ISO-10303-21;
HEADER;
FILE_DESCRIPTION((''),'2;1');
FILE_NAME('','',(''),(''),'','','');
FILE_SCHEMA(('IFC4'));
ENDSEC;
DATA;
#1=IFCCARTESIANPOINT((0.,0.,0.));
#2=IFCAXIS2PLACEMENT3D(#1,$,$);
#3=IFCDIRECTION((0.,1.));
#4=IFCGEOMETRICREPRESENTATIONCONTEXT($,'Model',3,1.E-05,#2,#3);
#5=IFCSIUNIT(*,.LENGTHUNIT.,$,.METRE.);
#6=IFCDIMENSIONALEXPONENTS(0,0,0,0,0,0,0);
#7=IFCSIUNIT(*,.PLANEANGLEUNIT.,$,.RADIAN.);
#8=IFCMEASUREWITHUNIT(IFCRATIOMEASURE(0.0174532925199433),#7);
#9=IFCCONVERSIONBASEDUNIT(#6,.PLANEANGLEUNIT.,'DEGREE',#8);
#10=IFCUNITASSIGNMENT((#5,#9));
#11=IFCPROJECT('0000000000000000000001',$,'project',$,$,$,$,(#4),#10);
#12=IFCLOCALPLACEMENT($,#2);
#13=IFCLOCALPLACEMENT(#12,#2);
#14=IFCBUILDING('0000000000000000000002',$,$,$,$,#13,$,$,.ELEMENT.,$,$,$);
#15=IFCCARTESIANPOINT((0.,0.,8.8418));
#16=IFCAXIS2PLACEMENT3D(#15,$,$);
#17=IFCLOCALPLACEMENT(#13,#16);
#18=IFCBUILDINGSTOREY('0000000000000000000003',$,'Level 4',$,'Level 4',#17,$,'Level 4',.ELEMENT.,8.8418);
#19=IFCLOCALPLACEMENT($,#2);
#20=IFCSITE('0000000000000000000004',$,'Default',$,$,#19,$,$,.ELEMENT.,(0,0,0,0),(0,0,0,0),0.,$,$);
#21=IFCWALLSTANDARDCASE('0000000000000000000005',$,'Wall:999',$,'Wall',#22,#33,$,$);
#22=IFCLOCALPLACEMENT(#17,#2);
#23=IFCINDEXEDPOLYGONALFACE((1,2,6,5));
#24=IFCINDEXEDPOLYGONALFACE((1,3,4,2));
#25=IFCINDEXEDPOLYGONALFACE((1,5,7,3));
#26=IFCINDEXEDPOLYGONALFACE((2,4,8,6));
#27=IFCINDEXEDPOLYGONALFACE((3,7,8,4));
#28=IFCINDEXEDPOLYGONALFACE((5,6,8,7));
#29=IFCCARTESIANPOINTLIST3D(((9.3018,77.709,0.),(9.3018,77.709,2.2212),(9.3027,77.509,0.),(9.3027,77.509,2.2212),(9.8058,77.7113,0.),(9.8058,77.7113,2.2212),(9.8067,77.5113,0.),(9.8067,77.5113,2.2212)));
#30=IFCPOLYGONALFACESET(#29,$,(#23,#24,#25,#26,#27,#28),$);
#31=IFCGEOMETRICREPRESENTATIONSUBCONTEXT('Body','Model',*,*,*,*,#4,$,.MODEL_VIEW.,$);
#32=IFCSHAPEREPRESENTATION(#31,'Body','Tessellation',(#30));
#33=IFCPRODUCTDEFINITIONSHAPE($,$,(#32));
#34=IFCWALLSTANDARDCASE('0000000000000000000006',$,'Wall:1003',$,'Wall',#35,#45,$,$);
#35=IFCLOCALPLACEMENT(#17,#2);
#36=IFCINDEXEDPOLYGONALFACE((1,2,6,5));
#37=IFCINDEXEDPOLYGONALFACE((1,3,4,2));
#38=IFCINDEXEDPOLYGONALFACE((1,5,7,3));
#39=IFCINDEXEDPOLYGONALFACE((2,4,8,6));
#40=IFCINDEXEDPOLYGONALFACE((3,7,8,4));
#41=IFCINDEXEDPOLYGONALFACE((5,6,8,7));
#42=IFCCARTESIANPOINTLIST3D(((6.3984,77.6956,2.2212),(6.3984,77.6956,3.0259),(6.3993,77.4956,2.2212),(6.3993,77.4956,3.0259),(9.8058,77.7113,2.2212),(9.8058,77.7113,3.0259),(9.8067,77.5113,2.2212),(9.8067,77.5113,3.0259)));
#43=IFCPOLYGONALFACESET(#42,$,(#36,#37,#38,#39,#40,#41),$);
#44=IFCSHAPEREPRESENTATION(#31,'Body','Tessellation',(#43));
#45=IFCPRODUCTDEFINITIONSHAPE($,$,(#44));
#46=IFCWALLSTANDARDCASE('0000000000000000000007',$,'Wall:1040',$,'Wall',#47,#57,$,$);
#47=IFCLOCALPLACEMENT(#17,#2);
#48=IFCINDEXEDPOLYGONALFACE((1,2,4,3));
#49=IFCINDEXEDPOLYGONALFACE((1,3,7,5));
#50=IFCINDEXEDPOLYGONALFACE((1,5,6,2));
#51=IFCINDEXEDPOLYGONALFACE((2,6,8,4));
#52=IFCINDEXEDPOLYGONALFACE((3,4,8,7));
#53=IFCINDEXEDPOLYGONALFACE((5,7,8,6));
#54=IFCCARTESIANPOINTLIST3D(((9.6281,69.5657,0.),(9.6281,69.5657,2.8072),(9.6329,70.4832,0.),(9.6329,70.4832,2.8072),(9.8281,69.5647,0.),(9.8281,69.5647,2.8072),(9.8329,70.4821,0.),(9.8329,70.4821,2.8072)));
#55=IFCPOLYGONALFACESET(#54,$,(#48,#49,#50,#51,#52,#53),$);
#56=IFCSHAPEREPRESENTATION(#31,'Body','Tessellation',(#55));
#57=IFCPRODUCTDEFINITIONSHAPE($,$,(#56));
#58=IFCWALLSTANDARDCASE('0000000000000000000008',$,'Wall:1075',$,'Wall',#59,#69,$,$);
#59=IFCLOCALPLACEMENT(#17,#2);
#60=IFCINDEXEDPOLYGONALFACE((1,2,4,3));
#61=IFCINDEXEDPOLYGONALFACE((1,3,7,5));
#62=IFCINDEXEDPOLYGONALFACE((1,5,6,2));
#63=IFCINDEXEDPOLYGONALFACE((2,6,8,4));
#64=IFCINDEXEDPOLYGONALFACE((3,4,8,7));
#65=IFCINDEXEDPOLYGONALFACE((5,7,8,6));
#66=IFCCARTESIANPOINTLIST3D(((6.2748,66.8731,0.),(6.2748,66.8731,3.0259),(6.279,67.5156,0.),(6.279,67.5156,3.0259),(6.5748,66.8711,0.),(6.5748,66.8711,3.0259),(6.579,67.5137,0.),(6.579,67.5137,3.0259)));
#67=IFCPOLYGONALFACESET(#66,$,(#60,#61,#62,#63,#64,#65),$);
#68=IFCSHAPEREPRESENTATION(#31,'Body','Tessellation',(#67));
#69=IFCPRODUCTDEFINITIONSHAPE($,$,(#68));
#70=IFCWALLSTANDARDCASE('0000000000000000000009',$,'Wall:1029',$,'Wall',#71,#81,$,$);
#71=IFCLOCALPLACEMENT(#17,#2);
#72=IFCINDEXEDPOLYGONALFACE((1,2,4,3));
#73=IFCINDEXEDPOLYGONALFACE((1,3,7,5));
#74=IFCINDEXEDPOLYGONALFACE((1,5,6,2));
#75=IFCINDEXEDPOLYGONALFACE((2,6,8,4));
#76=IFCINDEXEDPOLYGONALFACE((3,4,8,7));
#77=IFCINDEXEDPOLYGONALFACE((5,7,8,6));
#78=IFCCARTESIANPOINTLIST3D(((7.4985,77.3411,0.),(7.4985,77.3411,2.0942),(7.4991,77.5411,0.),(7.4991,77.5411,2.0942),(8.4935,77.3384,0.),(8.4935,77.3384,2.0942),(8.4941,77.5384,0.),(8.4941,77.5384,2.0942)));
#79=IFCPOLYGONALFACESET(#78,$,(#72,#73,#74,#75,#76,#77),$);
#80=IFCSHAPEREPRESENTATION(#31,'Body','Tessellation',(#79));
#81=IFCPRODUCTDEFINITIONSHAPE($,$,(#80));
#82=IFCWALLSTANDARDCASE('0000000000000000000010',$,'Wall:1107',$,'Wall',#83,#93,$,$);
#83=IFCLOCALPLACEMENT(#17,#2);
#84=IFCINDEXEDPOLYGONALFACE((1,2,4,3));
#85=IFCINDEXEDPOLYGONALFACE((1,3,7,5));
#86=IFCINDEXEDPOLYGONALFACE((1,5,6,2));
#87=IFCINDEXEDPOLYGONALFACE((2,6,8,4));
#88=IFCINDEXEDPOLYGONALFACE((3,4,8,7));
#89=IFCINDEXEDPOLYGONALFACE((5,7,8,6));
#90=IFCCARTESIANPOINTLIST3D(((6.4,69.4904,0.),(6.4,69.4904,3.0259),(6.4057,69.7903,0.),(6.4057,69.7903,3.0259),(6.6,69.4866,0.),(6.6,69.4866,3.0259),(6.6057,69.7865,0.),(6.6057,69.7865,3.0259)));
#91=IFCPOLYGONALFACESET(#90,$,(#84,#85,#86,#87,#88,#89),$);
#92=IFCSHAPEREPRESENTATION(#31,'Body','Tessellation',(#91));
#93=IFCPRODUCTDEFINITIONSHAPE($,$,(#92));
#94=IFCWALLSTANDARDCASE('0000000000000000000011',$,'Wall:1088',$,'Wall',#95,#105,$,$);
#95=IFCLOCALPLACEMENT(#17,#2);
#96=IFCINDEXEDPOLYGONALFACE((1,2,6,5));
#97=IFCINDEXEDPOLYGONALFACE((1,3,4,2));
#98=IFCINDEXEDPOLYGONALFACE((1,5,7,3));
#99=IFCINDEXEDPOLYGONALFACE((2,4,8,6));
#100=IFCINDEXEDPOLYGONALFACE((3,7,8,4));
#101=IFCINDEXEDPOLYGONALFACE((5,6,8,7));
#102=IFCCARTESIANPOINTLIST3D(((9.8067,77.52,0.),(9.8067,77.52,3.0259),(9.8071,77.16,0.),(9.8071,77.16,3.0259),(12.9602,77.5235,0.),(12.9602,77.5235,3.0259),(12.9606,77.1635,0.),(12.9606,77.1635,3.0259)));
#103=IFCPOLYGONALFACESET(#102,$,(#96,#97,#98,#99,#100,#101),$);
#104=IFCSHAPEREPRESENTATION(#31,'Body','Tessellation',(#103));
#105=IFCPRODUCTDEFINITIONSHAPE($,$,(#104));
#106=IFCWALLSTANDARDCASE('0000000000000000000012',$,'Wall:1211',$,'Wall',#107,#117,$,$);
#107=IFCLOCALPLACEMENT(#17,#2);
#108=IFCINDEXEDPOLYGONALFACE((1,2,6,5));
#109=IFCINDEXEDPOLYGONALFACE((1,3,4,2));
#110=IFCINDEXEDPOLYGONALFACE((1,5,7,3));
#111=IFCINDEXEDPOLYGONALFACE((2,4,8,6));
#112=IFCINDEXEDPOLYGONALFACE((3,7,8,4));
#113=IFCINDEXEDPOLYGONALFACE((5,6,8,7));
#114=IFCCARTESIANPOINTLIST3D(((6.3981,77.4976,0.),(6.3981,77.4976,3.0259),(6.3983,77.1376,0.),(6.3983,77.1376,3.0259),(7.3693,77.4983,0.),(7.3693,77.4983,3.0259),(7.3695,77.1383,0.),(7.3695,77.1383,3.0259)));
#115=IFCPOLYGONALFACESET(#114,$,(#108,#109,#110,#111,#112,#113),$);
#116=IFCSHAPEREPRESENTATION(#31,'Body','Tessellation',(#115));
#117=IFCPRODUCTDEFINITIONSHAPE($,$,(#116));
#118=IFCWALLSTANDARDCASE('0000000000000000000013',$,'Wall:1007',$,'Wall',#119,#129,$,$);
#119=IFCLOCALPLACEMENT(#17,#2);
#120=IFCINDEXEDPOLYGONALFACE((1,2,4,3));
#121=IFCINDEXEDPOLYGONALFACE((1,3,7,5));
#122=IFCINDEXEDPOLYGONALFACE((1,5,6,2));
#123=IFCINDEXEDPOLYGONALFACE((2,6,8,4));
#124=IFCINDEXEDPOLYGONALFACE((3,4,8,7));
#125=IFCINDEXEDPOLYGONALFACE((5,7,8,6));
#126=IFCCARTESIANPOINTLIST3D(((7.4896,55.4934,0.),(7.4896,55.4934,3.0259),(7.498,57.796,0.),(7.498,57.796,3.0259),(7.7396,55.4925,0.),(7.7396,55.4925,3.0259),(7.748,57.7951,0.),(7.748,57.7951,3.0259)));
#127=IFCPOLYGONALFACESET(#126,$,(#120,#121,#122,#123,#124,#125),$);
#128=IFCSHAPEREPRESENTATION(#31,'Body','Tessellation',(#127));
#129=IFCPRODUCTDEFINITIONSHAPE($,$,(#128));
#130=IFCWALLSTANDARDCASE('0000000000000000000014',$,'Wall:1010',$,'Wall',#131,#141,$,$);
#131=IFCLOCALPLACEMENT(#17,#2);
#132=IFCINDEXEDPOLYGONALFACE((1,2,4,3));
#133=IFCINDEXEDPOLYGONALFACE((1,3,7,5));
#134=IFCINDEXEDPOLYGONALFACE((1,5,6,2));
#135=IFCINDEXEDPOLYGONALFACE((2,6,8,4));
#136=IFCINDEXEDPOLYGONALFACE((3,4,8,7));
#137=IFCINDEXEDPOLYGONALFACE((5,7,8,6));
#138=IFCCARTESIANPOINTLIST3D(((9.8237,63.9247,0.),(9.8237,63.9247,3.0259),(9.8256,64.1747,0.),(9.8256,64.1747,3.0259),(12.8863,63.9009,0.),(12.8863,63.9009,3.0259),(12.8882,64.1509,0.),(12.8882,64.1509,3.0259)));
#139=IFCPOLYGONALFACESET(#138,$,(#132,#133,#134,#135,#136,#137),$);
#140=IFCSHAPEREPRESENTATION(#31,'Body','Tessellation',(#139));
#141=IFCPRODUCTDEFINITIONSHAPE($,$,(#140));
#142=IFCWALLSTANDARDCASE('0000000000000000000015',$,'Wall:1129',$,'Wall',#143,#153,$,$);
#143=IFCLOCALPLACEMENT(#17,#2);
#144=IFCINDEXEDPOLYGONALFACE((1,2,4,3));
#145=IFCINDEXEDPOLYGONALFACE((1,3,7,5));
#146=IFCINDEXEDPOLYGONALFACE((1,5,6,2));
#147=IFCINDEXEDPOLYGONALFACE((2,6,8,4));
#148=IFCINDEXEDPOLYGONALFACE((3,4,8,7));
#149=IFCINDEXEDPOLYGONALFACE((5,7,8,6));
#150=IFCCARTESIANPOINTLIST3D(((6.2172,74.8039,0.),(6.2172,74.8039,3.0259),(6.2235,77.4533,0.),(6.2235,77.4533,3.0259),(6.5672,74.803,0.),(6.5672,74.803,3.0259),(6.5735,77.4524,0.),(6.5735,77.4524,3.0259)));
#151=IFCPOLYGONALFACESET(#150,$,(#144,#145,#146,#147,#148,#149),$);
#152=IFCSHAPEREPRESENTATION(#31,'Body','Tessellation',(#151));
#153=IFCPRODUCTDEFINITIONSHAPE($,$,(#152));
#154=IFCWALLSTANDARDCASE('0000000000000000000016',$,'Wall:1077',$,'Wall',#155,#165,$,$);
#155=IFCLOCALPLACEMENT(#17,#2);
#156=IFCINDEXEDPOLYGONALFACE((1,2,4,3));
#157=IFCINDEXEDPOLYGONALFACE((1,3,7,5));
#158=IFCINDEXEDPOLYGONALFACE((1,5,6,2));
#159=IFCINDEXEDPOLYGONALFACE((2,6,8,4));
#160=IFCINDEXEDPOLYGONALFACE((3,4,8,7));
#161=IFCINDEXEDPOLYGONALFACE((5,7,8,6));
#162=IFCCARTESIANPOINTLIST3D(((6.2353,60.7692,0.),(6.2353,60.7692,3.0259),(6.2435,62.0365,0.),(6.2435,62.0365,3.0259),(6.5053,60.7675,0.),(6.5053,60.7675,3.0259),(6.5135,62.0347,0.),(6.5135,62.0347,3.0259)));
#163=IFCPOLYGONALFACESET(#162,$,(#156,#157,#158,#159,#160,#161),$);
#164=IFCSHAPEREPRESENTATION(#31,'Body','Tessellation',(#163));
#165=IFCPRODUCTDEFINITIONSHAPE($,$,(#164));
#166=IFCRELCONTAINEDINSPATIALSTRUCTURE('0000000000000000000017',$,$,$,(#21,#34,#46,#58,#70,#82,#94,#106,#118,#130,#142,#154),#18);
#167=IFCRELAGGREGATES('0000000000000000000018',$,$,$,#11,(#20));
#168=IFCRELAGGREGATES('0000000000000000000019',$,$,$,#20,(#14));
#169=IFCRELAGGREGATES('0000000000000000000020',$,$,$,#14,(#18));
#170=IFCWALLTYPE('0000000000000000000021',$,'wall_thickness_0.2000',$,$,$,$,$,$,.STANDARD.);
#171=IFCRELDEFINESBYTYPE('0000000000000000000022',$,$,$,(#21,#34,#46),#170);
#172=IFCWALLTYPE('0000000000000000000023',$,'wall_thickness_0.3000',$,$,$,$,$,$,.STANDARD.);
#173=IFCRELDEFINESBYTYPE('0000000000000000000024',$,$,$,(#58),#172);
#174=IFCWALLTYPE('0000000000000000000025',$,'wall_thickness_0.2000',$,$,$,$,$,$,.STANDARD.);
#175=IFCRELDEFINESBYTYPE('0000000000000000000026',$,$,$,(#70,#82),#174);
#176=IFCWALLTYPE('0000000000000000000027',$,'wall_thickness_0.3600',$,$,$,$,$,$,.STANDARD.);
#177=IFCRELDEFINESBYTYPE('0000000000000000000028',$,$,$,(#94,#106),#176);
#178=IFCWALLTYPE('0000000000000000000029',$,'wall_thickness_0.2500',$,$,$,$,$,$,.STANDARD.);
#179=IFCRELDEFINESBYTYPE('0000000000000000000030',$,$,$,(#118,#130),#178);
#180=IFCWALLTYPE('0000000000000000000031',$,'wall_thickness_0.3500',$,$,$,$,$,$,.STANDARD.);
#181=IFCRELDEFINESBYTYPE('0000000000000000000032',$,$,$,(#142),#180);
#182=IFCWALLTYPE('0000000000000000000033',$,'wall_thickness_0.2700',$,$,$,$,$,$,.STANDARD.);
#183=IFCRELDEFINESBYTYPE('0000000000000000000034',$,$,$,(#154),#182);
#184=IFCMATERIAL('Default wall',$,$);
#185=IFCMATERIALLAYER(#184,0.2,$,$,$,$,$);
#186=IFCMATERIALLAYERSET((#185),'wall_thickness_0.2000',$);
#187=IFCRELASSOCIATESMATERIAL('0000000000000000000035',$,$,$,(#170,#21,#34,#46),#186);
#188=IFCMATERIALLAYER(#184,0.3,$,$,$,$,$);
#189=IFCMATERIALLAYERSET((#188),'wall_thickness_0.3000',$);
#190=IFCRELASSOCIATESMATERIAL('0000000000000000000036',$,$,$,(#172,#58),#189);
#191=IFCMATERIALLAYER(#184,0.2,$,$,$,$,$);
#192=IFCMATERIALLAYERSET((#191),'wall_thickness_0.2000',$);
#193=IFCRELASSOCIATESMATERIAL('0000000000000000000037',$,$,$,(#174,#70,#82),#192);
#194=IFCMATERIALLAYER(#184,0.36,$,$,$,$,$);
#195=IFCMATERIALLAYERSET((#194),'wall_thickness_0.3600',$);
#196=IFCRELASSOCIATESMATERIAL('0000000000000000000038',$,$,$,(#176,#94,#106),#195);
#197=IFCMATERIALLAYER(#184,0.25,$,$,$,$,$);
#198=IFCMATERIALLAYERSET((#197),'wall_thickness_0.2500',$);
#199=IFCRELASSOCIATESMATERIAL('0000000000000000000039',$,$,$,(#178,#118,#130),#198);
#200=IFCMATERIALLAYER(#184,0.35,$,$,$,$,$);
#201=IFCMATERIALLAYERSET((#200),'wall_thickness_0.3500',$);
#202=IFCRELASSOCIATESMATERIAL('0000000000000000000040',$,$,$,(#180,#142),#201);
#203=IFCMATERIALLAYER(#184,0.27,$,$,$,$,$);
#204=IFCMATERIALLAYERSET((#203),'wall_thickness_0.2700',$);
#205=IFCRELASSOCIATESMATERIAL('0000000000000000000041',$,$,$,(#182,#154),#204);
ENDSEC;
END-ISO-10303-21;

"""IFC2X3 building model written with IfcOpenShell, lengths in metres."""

from ifc_helpers import new_model, entity, si_unit, converted_unit, direction, frame, origin, place, context, subcontext, project, spatial, polyline, outline, extrude, material, layer, layer_set, layer_usage, type_object, element, save


model = new_model("IFC2X3")

# Units and contexts
model_context = context("Model", 3, precision=1e-05, world=origin(), true_north=direction((0.0, 1.0)))
body_context = subcontext(model_context, "Body", "Model", "MODEL_VIEW")
ifc_project = project(units=[si_unit("LENGTHUNIT", "METRE"), converted_unit("PLANEANGLEUNIT", "DEGREE", entity("IfcRatioMeasure", 0.0174532925199433), si_unit("PLANEANGLEUNIT", "RADIAN"), dimensions=[0, 0, 0, 0, 0, 0, 0])], contexts=[model_context])

# Site, building, storey
site_placement = place(None, origin())
site = spatial("IfcSite", under=ifc_project, at=site_placement, Name="Default", CompositionType="ELEMENT", RefLatitude=(0, 0, 0, 0), RefLongitude=(0, 0, 0, 0), RefElevation=0.0)
placement_1 = place(None, origin())
building_placement = place(placement_1, origin())
building = spatial("IfcBuilding", under=site, at=building_placement, CompositionType="ELEMENT")
storey_placement = place(building_placement, frame((0.0, 0.0, 8.8418)))
storey = spatial("IfcBuildingStorey", under=building, at=storey_placement, Name="Level 4", ObjectType="Level 4", LongName="Level 4", CompositionType="ELEMENT", Elevation=8.8418)

# Walls
ifc_material_1 = material(Name="Default wall")
ifc_layer_1 = layer(ifc_material_1, 0.2)
ifc_layer_set_1 = layer_set([ifc_layer_1], Name="wall_thickness_0.2000")
ifc_layer_usage_1 = layer_usage(ifc_layer_set_1, "AXIS2", "POSITIVE", -0.1)
wall_type_1 = type_object("IfcWallType", Name="wall_thickness_0.2000", PredefinedType="STANDARD", material=ifc_layer_set_1)
wall_1_placement = place(storey_placement, frame((9.3023, 77.609, 0.0), z_axis=(0.0, 0.0, 1.0), x_axis=(0.999989, 0.004632, 0.0)))
element("IfcWallStandardCase", 1, at=wall_1_placement, inside=storey, type_object=wall_type_1, material=ifc_layer_usage_1, Name="Wall:999", ObjectType="Wall", context=body_context, shape_type="SweptSolid", body=[
    extrude(outline(polyline([(0.504, -0.1), (0.504, 0.1), (0.0, 0.1), (0.0, -0.1), (0.504, -0.1)])), origin(), (0.0, 0.0, 1.0), 2.2212),
])
placement_2 = place(building_placement, frame((0.0, 0.0, 11.063)))
wall_2_placement = place(placement_2, frame((6.3989, 77.5956, 0.0), z_axis=(0.0, 0.0, 1.0), x_axis=(0.999989, 0.004624, 0.0)))
element("IfcWallStandardCase", 2, at=wall_2_placement, inside=storey, type_object=wall_type_1, material=ifc_layer_usage_1, Name="Wall:1003", ObjectType="Wall", context=body_context, shape_type="SweptSolid", body=[
    extrude(outline(polyline([(3.4074, -0.1), (3.4074, 0.1), (0.0, 0.1), (0.0, -0.1), (3.4074, -0.1)])), origin(), (0.0, 0.0, 1.0), 0.8047),
])
wall_3_placement = place(storey_placement, frame((9.7329, 70.4826, 0.0), z_axis=(0.0, 0.0, 1.0), x_axis=(-0.005284, -0.999986, 0.0)))
element("IfcWallStandardCase", 3, at=wall_3_placement, inside=storey, type_object=wall_type_1, material=ifc_layer_usage_1, Name="Wall:1040", ObjectType="Wall", context=body_context, shape_type="SweptSolid", body=[
    extrude(outline(polyline([(0.9174, -0.1), (0.9174, 0.1), (0.0, 0.1), (0.0, -0.1), (0.9174, -0.1)])), origin(), (0.0, 0.0, 1.0), 2.8072),
])
ifc_layer_2 = layer(ifc_material_1, 0.3)
ifc_layer_set_2 = layer_set([ifc_layer_2], Name="wall_thickness_0.3000")
ifc_layer_usage_2 = layer_usage(ifc_layer_set_2, "AXIS2", "POSITIVE", -0.15)
wall_type_2 = type_object("IfcWallType", Name="wall_thickness_0.3000", PredefinedType="STANDARD", material=ifc_layer_set_2)
wall_4_placement = place(storey_placement, frame((6.429, 67.5147, 0.0), z_axis=(0.0, 0.0, 1.0), x_axis=(-0.006481, -0.999979, 0.0)))
element("IfcWallStandardCase", 4, at=wall_4_placement, inside=storey, type_object=wall_type_2, material=ifc_layer_usage_2, Name="Wall:1075", ObjectType="Wall", context=body_context, shape_type="SweptSolid", body=[
    extrude(outline(polyline([(0.6426, -0.15), (0.6426, 0.15), (0.0, 0.15), (0.0, -0.15), (0.6426, -0.15)])), origin(), (0.0, 0.0, 1.0), 3.0259),
])
ifc_layer_3 = layer(ifc_material_1, 0.2)
ifc_layer_set_3 = layer_set([ifc_layer_3], Name="wall_thickness_0.2000")
ifc_layer_usage_3 = layer_usage(ifc_layer_set_3, "AXIS2", "POSITIVE", -0.1)
wall_type_3 = type_object("IfcWallType", Name="wall_thickness_0.2000", PredefinedType="STANDARD", material=ifc_layer_set_3)
wall_5_placement = place(storey_placement, frame((7.4988, 77.4411, 0.0), z_axis=(0.0, 0.0, 1.0), x_axis=(0.999996, -0.002722, 0.0)))
element("IfcWallStandardCase", 5, at=wall_5_placement, inside=storey, type_object=wall_type_3, material=ifc_layer_usage_3, Name="Wall:1029", ObjectType="Wall", context=body_context, shape_type="SweptSolid", body=[
    extrude(outline(polyline([(0.995, -0.1), (0.995, 0.1), (0.0, 0.1), (0.0, -0.1), (0.995, -0.1)])), origin(), (0.0, 0.0, 1.0), 2.0942),
])
wall_6_placement = place(storey_placement, frame((6.5057, 69.7884, 0.0), z_axis=(0.0, 0.0, 1.0), x_axis=(-0.018913, -0.999821, 0.0)))
element("IfcWallStandardCase", 6, at=wall_6_placement, inside=storey, type_object=wall_type_3, material=ifc_layer_usage_3, Name="Wall:1107", ObjectType="Wall", context=body_context, shape_type="SweptSolid", body=[
    extrude(outline(polyline([(0.3, -0.1), (0.3, 0.1), (0.0, 0.1), (0.0, -0.1), (0.3, -0.1)])), origin(), (0.0, 0.0, 1.0), 3.0259),
])
ifc_layer_4 = layer(ifc_material_1, 0.36)
ifc_layer_set_4 = layer_set([ifc_layer_4], Name="wall_thickness_0.3600")
ifc_layer_usage_4 = layer_usage(ifc_layer_set_4, "AXIS2", "POSITIVE", -0.18)
wall_type_4 = type_object("IfcWallType", Name="wall_thickness_0.3600", PredefinedType="STANDARD", material=ifc_layer_set_4)
wall_7_placement = place(storey_placement, frame((9.8069, 77.34, 0.0), z_axis=(0.0, 0.0, 1.0), x_axis=(0.999999, 0.001125, 0.0)))
element("IfcWallStandardCase", 7, at=wall_7_placement, inside=storey, type_object=wall_type_4, material=ifc_layer_usage_4, Name="Wall:1088", ObjectType="Wall", context=body_context, shape_type="SweptSolid", body=[
    extrude(outline(polyline([(3.1535, -0.18), (3.1535, 0.18), (0.0, 0.18), (0.0, -0.18), (3.1535, -0.18)])), origin(), (0.0, 0.0, 1.0), 3.0259),
])
wall_8_placement = place(storey_placement, frame((6.3982, 77.3176, 0.0), z_axis=(0.0, 0.0, 1.0), x_axis=(1.0, 0.00066, 0.0)))
element("IfcWallStandardCase", 8, at=wall_8_placement, inside=storey, type_object=wall_type_4, material=ifc_layer_usage_4, Name="Wall:1211", ObjectType="Wall", context=body_context, shape_type="SweptSolid", body=[
    extrude(outline(polyline([(0.9712, -0.18), (0.9712, 0.18), (0.0, 0.18), (0.0, -0.18), (0.9712, -0.18)])), origin(), (0.0, 0.0, 1.0), 3.0259),
])
ifc_layer_5 = layer(ifc_material_1, 0.25)
ifc_layer_set_5 = layer_set([ifc_layer_5], Name="wall_thickness_0.2500")
ifc_layer_usage_5 = layer_usage(ifc_layer_set_5, "AXIS2", "POSITIVE", -0.125)
wall_type_5 = type_object("IfcWallType", Name="wall_thickness_0.2500", PredefinedType="STANDARD", material=ifc_layer_set_5)
wall_9_placement = place(storey_placement, frame((7.623, 57.7955, 0.0), z_axis=(0.0, 0.0, 1.0), x_axis=(-0.003619, -0.999993, 0.0)))
element("IfcWallStandardCase", 9, at=wall_9_placement, inside=storey, type_object=wall_type_5, material=ifc_layer_usage_5, Name="Wall:1007", ObjectType="Wall", context=body_context, shape_type="SweptSolid", body=[
    extrude(outline(polyline([(2.3026, -0.125), (2.3026, 0.125), (0.0, 0.125), (0.0, -0.125), (2.3026, -0.125)])), origin(), (0.0, 0.0, 1.0), 3.0259),
])
wall_10_placement = place(storey_placement, frame((9.8247, 64.0497, 0.0), z_axis=(0.0, 0.0, 1.0), x_axis=(0.99997, -0.007777, 0.0)))
element("IfcWallStandardCase", 10, at=wall_10_placement, inside=storey, type_object=wall_type_5, material=ifc_layer_usage_5, Name="Wall:1010", ObjectType="Wall", context=body_context, shape_type="SweptSolid", body=[
    extrude(outline(polyline([(3.0627, -0.125), (3.0627, 0.125), (0.0, 0.125), (0.0, -0.125), (3.0627, -0.125)])), origin(), (0.0, 0.0, 1.0), 3.0259),
])
ifc_layer_6 = layer(ifc_material_1, 0.35)
ifc_layer_set_6 = layer_set([ifc_layer_6], Name="wall_thickness_0.3500")
ifc_layer_usage_6 = layer_usage(ifc_layer_set_6, "AXIS2", "POSITIVE", -0.175)
wall_type_6 = type_object("IfcWallType", Name="wall_thickness_0.3500", PredefinedType="STANDARD", material=ifc_layer_set_6)
wall_11_placement = place(storey_placement, frame((6.3985, 77.4528, 0.0), z_axis=(0.0, 0.0, 1.0), x_axis=(-0.002371, -0.999997, 0.0)))
element("IfcWallStandardCase", 11, at=wall_11_placement, inside=storey, type_object=wall_type_6, material=ifc_layer_usage_6, Name="Wall:1129", ObjectType="Wall", context=body_context, shape_type="SweptSolid", body=[
    extrude(outline(polyline([(2.6494, -0.175), (2.6494, 0.175), (0.0, 0.175), (0.0, -0.175), (2.6494, -0.175)])), origin(), (0.0, 0.0, 1.0), 3.0259),
])
ifc_layer_7 = layer(ifc_material_1, 0.27)
ifc_layer_set_7 = layer_set([ifc_layer_7], Name="wall_thickness_0.2700")
ifc_layer_usage_7 = layer_usage(ifc_layer_set_7, "AXIS2", "POSITIVE", -0.135)
wall_type_7 = type_object("IfcWallType", Name="wall_thickness_0.2700", PredefinedType="STANDARD", material=ifc_layer_set_7)
wall_12_placement = place(storey_placement, frame((6.3785, 62.0356, 0.0), z_axis=(0.0, 0.0, 1.0), x_axis=(-0.006481, -0.999979, 0.0)))
element("IfcWallStandardCase", 12, at=wall_12_placement, inside=storey, type_object=wall_type_7, material=ifc_layer_usage_7, Name="Wall:1077", ObjectType="Wall", context=body_context, shape_type="SweptSolid", body=[
    extrude(outline(polyline([(1.2673, -0.135), (1.2673, 0.135), (0.0, 0.135), (0.0, -0.135), (1.2673, -0.135)])), origin(), (0.0, 0.0, 1.0), 3.0259),
])

save(model, "model.ifc")
